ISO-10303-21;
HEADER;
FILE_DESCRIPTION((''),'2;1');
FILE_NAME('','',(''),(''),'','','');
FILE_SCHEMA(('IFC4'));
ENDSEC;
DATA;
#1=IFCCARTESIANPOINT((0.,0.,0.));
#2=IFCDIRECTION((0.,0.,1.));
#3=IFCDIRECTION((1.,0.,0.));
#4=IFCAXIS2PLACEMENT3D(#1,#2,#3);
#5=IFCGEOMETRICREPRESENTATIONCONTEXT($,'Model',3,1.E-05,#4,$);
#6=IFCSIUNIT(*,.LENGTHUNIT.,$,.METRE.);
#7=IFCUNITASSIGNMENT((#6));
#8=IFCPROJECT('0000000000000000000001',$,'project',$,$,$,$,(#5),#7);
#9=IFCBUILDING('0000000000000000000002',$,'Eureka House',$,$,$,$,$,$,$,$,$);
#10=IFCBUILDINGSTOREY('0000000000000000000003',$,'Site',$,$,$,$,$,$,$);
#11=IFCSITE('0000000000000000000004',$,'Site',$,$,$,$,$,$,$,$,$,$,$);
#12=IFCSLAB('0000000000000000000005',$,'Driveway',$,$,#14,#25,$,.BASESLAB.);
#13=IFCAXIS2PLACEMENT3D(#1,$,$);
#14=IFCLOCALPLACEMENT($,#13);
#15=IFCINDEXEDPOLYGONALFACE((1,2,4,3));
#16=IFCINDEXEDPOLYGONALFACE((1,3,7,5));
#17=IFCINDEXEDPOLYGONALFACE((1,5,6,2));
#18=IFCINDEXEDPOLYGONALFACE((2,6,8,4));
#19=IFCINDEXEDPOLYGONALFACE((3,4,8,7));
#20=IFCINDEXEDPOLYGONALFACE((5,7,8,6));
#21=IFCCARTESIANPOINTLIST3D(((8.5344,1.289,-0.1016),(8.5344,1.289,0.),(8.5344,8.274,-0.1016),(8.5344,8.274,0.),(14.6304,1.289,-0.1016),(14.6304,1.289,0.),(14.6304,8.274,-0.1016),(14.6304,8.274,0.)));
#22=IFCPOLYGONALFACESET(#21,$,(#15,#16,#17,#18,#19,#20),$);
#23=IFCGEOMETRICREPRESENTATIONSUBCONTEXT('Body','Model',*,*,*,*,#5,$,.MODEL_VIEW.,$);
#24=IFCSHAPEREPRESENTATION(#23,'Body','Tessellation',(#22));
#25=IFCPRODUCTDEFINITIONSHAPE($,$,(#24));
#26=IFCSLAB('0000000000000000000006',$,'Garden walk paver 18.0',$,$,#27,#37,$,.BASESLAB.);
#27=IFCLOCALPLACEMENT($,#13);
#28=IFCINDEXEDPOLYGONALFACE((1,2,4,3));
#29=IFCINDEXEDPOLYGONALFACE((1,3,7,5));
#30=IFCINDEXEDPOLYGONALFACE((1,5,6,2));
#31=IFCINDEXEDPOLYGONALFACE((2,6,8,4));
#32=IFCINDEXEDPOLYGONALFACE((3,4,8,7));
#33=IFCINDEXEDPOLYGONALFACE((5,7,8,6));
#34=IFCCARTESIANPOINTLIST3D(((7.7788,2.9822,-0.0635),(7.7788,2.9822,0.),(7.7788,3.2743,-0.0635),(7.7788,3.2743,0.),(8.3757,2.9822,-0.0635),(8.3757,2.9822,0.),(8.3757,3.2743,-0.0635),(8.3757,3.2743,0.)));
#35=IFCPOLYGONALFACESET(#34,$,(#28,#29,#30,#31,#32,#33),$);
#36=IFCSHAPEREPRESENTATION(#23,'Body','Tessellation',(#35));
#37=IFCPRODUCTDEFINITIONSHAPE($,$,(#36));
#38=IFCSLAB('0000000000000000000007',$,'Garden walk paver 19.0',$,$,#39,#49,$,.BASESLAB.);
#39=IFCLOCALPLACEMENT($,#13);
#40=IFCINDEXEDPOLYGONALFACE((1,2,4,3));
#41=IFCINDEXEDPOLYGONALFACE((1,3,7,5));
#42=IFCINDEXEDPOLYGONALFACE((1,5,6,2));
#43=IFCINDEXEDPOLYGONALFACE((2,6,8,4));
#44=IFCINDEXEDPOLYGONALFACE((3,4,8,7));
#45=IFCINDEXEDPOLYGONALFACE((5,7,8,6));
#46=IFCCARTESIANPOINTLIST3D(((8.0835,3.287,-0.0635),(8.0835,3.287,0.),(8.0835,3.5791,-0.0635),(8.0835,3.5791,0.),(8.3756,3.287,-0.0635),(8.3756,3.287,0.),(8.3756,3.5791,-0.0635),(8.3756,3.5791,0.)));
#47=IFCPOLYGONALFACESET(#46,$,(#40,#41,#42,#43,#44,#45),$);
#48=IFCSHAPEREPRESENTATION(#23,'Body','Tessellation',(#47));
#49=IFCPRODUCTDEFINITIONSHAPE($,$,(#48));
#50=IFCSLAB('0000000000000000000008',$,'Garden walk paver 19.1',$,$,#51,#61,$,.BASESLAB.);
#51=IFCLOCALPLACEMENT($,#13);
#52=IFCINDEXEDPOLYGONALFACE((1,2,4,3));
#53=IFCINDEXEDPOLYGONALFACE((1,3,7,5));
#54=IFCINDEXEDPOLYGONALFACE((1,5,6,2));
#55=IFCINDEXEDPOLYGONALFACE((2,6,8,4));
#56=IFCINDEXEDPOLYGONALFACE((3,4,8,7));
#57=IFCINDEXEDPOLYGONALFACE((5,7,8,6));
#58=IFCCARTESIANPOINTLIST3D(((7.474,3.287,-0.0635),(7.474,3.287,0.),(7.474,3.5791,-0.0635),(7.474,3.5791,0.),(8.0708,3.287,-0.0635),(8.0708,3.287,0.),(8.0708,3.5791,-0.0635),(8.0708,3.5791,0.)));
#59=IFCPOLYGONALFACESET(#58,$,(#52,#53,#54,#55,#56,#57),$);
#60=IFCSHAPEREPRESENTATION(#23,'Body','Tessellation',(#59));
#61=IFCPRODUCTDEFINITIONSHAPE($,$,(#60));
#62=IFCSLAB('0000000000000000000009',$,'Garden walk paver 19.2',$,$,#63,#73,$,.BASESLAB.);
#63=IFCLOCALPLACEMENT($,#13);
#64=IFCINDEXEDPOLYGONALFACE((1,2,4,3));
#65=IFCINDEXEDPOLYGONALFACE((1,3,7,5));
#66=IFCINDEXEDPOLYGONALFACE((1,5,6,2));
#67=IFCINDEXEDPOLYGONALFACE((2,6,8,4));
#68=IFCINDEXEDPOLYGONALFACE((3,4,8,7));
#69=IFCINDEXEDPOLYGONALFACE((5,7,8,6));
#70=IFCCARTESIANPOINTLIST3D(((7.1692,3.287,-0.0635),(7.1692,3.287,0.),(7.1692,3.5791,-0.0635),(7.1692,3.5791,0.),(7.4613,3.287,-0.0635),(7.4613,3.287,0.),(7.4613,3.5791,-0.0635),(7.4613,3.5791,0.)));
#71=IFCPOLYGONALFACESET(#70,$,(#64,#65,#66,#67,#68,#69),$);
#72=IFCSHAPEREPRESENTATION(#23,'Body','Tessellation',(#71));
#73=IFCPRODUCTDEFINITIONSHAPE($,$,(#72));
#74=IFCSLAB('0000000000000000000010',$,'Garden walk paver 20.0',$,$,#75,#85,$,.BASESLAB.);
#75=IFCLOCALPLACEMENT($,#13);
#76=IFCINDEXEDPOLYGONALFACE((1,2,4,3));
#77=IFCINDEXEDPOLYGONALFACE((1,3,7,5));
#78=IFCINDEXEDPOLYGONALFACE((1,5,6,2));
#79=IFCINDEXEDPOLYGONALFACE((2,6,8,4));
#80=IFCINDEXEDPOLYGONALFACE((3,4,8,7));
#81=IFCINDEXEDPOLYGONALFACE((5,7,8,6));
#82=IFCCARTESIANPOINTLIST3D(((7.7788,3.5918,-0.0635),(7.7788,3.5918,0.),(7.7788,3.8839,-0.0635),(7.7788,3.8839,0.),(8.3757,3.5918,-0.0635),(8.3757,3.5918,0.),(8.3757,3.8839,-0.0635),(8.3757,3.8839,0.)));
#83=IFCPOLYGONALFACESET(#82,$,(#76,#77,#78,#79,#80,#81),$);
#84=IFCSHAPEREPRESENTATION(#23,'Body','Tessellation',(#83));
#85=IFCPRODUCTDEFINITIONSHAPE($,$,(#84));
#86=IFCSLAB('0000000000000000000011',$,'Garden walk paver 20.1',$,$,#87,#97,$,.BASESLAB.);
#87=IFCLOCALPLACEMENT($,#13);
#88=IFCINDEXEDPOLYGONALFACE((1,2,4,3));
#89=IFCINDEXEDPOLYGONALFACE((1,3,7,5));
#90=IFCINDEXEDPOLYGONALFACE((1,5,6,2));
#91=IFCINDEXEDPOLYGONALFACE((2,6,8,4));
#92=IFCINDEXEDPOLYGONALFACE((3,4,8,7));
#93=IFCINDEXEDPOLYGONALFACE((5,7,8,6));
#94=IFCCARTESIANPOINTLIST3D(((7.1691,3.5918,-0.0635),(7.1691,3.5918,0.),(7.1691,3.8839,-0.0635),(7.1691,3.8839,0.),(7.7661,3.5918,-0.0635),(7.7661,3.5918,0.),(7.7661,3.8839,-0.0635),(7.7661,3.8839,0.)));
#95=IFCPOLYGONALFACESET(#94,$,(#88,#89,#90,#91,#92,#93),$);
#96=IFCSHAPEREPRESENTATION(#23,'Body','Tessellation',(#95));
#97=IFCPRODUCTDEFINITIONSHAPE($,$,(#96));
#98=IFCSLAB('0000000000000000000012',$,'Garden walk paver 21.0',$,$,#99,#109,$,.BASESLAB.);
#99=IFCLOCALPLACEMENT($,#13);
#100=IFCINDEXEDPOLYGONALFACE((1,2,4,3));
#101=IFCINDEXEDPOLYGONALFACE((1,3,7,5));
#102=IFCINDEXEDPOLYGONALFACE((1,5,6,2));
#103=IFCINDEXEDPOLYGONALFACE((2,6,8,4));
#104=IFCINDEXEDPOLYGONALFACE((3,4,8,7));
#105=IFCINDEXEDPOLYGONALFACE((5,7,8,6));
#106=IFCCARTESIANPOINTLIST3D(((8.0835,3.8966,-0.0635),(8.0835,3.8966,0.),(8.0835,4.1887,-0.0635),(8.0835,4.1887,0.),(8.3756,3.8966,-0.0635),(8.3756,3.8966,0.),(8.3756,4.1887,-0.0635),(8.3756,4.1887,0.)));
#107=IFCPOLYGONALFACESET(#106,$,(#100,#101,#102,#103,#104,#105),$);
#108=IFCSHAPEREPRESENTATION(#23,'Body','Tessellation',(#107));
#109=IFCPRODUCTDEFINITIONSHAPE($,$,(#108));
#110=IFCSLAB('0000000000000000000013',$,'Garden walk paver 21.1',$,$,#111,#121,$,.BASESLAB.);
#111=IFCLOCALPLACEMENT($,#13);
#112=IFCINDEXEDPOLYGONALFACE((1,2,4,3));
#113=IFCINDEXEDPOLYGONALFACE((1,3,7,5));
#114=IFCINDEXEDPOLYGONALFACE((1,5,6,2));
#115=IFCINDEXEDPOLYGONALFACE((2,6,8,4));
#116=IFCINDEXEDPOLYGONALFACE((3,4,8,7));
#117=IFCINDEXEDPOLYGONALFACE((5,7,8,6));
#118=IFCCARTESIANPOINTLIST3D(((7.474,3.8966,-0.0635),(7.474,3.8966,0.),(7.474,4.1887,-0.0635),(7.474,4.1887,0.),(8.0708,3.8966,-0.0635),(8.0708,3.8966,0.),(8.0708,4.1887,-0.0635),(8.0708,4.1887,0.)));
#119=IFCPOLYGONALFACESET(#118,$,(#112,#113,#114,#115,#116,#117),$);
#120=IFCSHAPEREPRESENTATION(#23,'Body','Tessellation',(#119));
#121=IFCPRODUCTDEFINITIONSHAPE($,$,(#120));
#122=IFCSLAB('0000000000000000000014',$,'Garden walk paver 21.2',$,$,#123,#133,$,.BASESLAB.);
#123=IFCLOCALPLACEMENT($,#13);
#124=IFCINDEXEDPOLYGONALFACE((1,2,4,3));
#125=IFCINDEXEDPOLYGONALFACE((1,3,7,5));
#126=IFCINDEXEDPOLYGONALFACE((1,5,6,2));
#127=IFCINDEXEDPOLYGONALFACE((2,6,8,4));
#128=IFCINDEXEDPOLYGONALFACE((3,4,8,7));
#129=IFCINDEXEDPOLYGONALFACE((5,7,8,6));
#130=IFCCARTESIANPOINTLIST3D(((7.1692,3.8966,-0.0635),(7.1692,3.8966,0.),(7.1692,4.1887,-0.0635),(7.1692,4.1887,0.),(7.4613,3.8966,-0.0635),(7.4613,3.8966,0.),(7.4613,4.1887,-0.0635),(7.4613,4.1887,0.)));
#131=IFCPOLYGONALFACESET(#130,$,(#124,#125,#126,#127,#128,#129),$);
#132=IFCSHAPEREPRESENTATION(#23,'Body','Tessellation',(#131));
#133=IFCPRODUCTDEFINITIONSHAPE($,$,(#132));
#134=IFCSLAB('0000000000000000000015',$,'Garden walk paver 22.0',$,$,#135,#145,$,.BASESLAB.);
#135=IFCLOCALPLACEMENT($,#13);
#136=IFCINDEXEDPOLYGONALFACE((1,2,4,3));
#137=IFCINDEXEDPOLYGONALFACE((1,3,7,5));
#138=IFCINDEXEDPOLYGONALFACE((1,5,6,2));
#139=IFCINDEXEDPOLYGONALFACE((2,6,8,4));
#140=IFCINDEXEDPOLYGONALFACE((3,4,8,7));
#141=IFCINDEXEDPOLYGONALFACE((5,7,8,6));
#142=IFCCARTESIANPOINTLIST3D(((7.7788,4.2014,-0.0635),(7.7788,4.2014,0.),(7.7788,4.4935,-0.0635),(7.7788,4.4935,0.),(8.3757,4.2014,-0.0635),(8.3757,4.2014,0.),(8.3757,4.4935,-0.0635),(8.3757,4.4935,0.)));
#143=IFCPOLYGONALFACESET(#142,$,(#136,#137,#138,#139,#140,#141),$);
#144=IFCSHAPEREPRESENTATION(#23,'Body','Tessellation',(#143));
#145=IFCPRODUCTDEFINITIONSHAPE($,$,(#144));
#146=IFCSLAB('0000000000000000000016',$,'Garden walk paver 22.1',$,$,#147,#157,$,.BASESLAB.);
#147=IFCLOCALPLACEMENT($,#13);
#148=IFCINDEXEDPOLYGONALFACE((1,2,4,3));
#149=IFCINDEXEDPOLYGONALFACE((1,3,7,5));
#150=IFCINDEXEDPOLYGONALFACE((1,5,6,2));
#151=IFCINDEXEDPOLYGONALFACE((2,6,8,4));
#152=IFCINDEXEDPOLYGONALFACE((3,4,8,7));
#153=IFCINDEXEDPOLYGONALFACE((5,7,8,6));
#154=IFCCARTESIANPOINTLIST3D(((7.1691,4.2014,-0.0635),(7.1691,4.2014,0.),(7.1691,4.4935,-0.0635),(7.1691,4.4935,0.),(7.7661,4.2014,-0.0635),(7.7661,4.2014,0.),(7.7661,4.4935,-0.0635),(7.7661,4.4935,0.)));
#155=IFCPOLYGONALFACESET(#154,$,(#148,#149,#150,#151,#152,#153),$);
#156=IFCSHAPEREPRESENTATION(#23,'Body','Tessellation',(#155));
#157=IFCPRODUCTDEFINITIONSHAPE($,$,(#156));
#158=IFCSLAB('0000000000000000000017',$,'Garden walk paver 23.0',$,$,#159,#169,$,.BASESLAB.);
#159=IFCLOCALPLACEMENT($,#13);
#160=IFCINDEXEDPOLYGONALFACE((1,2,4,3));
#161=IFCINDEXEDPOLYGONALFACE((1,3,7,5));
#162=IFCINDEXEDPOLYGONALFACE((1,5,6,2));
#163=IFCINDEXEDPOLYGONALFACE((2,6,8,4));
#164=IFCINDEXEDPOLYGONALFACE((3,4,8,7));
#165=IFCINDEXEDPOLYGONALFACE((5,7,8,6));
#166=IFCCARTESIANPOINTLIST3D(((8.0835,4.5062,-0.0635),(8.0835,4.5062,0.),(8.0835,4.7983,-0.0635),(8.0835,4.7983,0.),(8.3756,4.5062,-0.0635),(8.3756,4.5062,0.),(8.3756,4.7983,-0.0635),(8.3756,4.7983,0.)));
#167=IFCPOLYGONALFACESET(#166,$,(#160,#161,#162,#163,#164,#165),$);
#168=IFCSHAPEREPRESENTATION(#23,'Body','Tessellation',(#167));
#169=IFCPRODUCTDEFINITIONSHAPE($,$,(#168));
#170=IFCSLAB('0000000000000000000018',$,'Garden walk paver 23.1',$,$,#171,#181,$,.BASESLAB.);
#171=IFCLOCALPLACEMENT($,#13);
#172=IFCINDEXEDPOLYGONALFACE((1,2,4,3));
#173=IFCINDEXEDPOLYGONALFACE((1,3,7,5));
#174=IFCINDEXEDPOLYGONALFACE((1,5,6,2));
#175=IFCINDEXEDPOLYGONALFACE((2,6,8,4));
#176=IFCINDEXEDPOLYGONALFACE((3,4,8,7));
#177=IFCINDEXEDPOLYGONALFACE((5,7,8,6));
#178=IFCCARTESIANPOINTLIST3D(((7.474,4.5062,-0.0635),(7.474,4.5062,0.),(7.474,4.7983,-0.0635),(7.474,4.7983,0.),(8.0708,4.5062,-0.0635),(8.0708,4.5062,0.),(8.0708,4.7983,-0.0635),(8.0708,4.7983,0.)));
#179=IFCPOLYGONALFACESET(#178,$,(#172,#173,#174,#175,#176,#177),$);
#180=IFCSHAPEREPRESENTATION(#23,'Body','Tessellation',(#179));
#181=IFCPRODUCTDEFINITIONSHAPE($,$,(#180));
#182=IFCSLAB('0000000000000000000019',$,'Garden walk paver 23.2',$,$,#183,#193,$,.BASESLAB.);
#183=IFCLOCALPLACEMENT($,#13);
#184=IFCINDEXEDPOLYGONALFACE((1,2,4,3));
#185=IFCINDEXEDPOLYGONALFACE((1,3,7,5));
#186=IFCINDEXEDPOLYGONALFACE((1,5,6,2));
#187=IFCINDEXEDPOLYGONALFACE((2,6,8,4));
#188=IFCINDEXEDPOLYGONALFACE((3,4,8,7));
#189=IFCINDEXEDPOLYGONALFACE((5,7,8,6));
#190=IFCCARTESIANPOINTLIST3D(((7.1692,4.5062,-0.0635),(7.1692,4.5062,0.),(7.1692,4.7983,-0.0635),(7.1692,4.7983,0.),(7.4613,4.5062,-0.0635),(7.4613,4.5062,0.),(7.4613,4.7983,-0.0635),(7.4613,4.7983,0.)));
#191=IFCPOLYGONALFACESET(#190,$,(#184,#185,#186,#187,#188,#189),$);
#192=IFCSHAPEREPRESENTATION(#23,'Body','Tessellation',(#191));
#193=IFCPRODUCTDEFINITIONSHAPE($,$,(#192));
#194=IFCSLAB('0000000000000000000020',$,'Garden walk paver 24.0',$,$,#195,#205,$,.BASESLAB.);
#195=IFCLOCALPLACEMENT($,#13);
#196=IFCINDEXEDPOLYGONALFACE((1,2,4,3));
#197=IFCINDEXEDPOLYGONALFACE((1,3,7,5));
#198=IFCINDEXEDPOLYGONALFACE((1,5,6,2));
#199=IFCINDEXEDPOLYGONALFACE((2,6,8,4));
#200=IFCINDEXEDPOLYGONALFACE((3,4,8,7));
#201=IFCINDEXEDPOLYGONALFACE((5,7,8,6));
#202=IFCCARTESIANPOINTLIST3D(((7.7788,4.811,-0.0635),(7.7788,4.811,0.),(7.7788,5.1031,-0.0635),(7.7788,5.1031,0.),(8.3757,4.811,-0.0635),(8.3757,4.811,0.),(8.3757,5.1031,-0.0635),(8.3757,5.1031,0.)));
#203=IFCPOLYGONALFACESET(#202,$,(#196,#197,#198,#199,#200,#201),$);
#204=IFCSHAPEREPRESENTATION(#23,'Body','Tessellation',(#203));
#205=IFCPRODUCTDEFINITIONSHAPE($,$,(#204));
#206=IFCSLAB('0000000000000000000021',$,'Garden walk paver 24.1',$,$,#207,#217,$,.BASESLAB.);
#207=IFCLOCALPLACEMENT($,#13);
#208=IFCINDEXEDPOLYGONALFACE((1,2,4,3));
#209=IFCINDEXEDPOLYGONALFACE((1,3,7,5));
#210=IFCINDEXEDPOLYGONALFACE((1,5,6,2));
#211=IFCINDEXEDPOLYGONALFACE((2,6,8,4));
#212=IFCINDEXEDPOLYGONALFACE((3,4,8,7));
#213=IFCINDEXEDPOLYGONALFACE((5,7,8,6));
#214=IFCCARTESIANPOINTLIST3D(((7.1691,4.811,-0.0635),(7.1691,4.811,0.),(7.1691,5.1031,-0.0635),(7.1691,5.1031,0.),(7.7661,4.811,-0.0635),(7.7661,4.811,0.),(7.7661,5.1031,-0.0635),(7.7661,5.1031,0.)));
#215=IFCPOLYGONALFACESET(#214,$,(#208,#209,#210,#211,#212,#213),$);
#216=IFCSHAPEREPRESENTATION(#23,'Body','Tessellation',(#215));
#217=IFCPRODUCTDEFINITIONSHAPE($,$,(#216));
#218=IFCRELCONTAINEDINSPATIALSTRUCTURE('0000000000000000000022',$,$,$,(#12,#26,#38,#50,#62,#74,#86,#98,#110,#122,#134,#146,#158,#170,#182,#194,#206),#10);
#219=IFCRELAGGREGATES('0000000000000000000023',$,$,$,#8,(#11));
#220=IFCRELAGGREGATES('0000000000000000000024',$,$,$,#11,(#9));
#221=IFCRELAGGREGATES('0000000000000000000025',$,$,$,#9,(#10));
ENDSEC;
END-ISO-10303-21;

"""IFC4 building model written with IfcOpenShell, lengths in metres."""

from ifc_helpers import new_model, si_unit, frame, origin, origin_with_axes, origin_2d, place, context, subcontext, project, spatial, rectangle, extrude, element, save


model = new_model("IFC4")

# Units and contexts
model_context = context("Model", 3, precision=1e-05, world=origin_with_axes())
body_context = subcontext(model_context, "Body", "Model", "MODEL_VIEW")
ifc_project = project(units=[si_unit("LENGTHUNIT", "METRE")], contexts=[model_context])

# Site, building, storey
site = spatial("IfcSite", under=ifc_project, Name="Site")
building = spatial("IfcBuilding", under=site, Name="Eureka House")
storey = spatial("IfcBuildingStorey", under=building, Name="Site")

# Slabs
slab_1_placement = place(None, frame((11.5824, 4.7815, -0.1016), z_axis=(0.0, 0.0, 1.0), x_axis=(1.0, 0.0, 0.0)))
element("IfcSlab", 1, at=slab_1_placement, inside=storey, Name="Driveway", PredefinedType="BASESLAB", context=body_context, shape_type="SweptSolid", body=[
    extrude(rectangle(XDim=6.096, YDim=6.985, at=origin_2d()), origin(), (0.0, 0.0, 1.0), 0.1016),
])
slab_2_placement = place(None, frame((8.0772, 3.1283, -0.0635), z_axis=(0.0, 0.0, 1.0), x_axis=(1.0, 0.0, 0.0)))
element("IfcSlab", 2, at=slab_2_placement, inside=storey, Name="Garden walk paver 18.0", PredefinedType="BASESLAB", context=body_context, shape_type="SweptSolid", body=[
    extrude(rectangle(XDim=0.5969, YDim=0.2921, at=origin_2d()), origin(), (0.0, 0.0, 1.0), 0.0635),
])
slab_3_placement = place(None, frame((8.2296, 3.4331, -0.0635), z_axis=(0.0, 0.0, 1.0), x_axis=(1.0, 0.0, 0.0)))
element("IfcSlab", 3, at=slab_3_placement, inside=storey, Name="Garden walk paver 19.0", PredefinedType="BASESLAB", context=body_context, shape_type="SweptSolid", body=[
    extrude(rectangle(XDim=0.2921, YDim=0.2921, at=origin_2d()), origin(), (0.0, 0.0, 1.0), 0.0635),
])
slab_4_placement = place(None, frame((7.7724, 3.4331, -0.0635), z_axis=(0.0, 0.0, 1.0), x_axis=(1.0, 0.0, 0.0)))
element("IfcSlab", 4, at=slab_4_placement, inside=storey, Name="Garden walk paver 19.1", PredefinedType="BASESLAB", context=body_context, shape_type="SweptSolid", body=[
    extrude(rectangle(XDim=0.5969, YDim=0.2921, at=origin_2d()), origin(), (0.0, 0.0, 1.0), 0.0635),
])
slab_5_placement = place(None, frame((7.3152, 3.4331, -0.0635), z_axis=(0.0, 0.0, 1.0), x_axis=(1.0, 0.0, 0.0)))
element("IfcSlab", 5, at=slab_5_placement, inside=storey, Name="Garden walk paver 19.2", PredefinedType="BASESLAB", context=body_context, shape_type="SweptSolid", body=[
    extrude(rectangle(XDim=0.2921, YDim=0.2921, at=origin_2d()), origin(), (0.0, 0.0, 1.0), 0.0635),
])
for number, where, z_axis, x_axis, name in (
    (6, (8.0772, 3.7379, -0.0635), (0.0, 0.0, 1.0), (1.0, 0.0, 0.0), "Garden walk paver 20.0"),
    (7, (7.4676, 3.7379, -0.0635), (0.0, 0.0, 1.0), (1.0, 0.0, 0.0), "Garden walk paver 20.1"),
):
    element("IfcSlab", number, at=place(None, frame(where, z_axis=z_axis, x_axis=x_axis)), inside=storey, Name=name, PredefinedType="BASESLAB", context=body_context, shape_type="SweptSolid", body=[
        extrude(rectangle(XDim=0.5969, YDim=0.2921, at=origin_2d()), origin(), (0.0, 0.0, 1.0), 0.0635),
    ])
slab_6_placement = place(None, frame((8.2296, 4.0427, -0.0635), z_axis=(0.0, 0.0, 1.0), x_axis=(1.0, 0.0, 0.0)))
element("IfcSlab", 8, at=slab_6_placement, inside=storey, Name="Garden walk paver 21.0", PredefinedType="BASESLAB", context=body_context, shape_type="SweptSolid", body=[
    extrude(rectangle(XDim=0.2921, YDim=0.2921, at=origin_2d()), origin(), (0.0, 0.0, 1.0), 0.0635),
])
slab_7_placement = place(None, frame((7.7724, 4.0427, -0.0635), z_axis=(0.0, 0.0, 1.0), x_axis=(1.0, 0.0, 0.0)))
element("IfcSlab", 9, at=slab_7_placement, inside=storey, Name="Garden walk paver 21.1", PredefinedType="BASESLAB", context=body_context, shape_type="SweptSolid", body=[
    extrude(rectangle(XDim=0.5969, YDim=0.2921, at=origin_2d()), origin(), (0.0, 0.0, 1.0), 0.0635),
])
slab_8_placement = place(None, frame((7.3152, 4.0427, -0.0635), z_axis=(0.0, 0.0, 1.0), x_axis=(1.0, 0.0, 0.0)))
element("IfcSlab", 10, at=slab_8_placement, inside=storey, Name="Garden walk paver 21.2", PredefinedType="BASESLAB", context=body_context, shape_type="SweptSolid", body=[
    extrude(rectangle(XDim=0.2921, YDim=0.2921, at=origin_2d()), origin(), (0.0, 0.0, 1.0), 0.0635),
])
for number, where, z_axis, x_axis, name in (
    (11, (8.0772, 4.3475, -0.0635), (0.0, 0.0, 1.0), (1.0, 0.0, 0.0), "Garden walk paver 22.0"),
    (12, (7.4676, 4.3475, -0.0635), (0.0, 0.0, 1.0), (1.0, 0.0, 0.0), "Garden walk paver 22.1"),
):
    element("IfcSlab", number, at=place(None, frame(where, z_axis=z_axis, x_axis=x_axis)), inside=storey, Name=name, PredefinedType="BASESLAB", context=body_context, shape_type="SweptSolid", body=[
        extrude(rectangle(XDim=0.5969, YDim=0.2921, at=origin_2d()), origin(), (0.0, 0.0, 1.0), 0.0635),
    ])
slab_9_placement = place(None, frame((8.2296, 4.6523, -0.0635), z_axis=(0.0, 0.0, 1.0), x_axis=(1.0, 0.0, 0.0)))
element("IfcSlab", 13, at=slab_9_placement, inside=storey, Name="Garden walk paver 23.0", PredefinedType="BASESLAB", context=body_context, shape_type="SweptSolid", body=[
    extrude(rectangle(XDim=0.2921, YDim=0.2921, at=origin_2d()), origin(), (0.0, 0.0, 1.0), 0.0635),
])
slab_10_placement = place(None, frame((7.7724, 4.6523, -0.0635), z_axis=(0.0, 0.0, 1.0), x_axis=(1.0, 0.0, 0.0)))
element("IfcSlab", 14, at=slab_10_placement, inside=storey, Name="Garden walk paver 23.1", PredefinedType="BASESLAB", context=body_context, shape_type="SweptSolid", body=[
    extrude(rectangle(XDim=0.5969, YDim=0.2921, at=origin_2d()), origin(), (0.0, 0.0, 1.0), 0.0635),
])
slab_11_placement = place(None, frame((7.3152, 4.6523, -0.0635), z_axis=(0.0, 0.0, 1.0), x_axis=(1.0, 0.0, 0.0)))
element("IfcSlab", 15, at=slab_11_placement, inside=storey, Name="Garden walk paver 23.2", PredefinedType="BASESLAB", context=body_context, shape_type="SweptSolid", body=[
    extrude(rectangle(XDim=0.2921, YDim=0.2921, at=origin_2d()), origin(), (0.0, 0.0, 1.0), 0.0635),
])
for number, where, z_axis, x_axis, name in (
    (16, (8.0772, 4.9571, -0.0635), (0.0, 0.0, 1.0), (1.0, 0.0, 0.0), "Garden walk paver 24.0"),
    (17, (7.4676, 4.9571, -0.0635), (0.0, 0.0, 1.0), (1.0, 0.0, 0.0), "Garden walk paver 24.1"),
):
    element("IfcSlab", number, at=place(None, frame(where, z_axis=z_axis, x_axis=x_axis)), inside=storey, Name=name, PredefinedType="BASESLAB", context=body_context, shape_type="SweptSolid", body=[
        extrude(rectangle(XDim=0.5969, YDim=0.2921, at=origin_2d()), origin(), (0.0, 0.0, 1.0), 0.0635),
    ])

save(model, "model.ifc")
